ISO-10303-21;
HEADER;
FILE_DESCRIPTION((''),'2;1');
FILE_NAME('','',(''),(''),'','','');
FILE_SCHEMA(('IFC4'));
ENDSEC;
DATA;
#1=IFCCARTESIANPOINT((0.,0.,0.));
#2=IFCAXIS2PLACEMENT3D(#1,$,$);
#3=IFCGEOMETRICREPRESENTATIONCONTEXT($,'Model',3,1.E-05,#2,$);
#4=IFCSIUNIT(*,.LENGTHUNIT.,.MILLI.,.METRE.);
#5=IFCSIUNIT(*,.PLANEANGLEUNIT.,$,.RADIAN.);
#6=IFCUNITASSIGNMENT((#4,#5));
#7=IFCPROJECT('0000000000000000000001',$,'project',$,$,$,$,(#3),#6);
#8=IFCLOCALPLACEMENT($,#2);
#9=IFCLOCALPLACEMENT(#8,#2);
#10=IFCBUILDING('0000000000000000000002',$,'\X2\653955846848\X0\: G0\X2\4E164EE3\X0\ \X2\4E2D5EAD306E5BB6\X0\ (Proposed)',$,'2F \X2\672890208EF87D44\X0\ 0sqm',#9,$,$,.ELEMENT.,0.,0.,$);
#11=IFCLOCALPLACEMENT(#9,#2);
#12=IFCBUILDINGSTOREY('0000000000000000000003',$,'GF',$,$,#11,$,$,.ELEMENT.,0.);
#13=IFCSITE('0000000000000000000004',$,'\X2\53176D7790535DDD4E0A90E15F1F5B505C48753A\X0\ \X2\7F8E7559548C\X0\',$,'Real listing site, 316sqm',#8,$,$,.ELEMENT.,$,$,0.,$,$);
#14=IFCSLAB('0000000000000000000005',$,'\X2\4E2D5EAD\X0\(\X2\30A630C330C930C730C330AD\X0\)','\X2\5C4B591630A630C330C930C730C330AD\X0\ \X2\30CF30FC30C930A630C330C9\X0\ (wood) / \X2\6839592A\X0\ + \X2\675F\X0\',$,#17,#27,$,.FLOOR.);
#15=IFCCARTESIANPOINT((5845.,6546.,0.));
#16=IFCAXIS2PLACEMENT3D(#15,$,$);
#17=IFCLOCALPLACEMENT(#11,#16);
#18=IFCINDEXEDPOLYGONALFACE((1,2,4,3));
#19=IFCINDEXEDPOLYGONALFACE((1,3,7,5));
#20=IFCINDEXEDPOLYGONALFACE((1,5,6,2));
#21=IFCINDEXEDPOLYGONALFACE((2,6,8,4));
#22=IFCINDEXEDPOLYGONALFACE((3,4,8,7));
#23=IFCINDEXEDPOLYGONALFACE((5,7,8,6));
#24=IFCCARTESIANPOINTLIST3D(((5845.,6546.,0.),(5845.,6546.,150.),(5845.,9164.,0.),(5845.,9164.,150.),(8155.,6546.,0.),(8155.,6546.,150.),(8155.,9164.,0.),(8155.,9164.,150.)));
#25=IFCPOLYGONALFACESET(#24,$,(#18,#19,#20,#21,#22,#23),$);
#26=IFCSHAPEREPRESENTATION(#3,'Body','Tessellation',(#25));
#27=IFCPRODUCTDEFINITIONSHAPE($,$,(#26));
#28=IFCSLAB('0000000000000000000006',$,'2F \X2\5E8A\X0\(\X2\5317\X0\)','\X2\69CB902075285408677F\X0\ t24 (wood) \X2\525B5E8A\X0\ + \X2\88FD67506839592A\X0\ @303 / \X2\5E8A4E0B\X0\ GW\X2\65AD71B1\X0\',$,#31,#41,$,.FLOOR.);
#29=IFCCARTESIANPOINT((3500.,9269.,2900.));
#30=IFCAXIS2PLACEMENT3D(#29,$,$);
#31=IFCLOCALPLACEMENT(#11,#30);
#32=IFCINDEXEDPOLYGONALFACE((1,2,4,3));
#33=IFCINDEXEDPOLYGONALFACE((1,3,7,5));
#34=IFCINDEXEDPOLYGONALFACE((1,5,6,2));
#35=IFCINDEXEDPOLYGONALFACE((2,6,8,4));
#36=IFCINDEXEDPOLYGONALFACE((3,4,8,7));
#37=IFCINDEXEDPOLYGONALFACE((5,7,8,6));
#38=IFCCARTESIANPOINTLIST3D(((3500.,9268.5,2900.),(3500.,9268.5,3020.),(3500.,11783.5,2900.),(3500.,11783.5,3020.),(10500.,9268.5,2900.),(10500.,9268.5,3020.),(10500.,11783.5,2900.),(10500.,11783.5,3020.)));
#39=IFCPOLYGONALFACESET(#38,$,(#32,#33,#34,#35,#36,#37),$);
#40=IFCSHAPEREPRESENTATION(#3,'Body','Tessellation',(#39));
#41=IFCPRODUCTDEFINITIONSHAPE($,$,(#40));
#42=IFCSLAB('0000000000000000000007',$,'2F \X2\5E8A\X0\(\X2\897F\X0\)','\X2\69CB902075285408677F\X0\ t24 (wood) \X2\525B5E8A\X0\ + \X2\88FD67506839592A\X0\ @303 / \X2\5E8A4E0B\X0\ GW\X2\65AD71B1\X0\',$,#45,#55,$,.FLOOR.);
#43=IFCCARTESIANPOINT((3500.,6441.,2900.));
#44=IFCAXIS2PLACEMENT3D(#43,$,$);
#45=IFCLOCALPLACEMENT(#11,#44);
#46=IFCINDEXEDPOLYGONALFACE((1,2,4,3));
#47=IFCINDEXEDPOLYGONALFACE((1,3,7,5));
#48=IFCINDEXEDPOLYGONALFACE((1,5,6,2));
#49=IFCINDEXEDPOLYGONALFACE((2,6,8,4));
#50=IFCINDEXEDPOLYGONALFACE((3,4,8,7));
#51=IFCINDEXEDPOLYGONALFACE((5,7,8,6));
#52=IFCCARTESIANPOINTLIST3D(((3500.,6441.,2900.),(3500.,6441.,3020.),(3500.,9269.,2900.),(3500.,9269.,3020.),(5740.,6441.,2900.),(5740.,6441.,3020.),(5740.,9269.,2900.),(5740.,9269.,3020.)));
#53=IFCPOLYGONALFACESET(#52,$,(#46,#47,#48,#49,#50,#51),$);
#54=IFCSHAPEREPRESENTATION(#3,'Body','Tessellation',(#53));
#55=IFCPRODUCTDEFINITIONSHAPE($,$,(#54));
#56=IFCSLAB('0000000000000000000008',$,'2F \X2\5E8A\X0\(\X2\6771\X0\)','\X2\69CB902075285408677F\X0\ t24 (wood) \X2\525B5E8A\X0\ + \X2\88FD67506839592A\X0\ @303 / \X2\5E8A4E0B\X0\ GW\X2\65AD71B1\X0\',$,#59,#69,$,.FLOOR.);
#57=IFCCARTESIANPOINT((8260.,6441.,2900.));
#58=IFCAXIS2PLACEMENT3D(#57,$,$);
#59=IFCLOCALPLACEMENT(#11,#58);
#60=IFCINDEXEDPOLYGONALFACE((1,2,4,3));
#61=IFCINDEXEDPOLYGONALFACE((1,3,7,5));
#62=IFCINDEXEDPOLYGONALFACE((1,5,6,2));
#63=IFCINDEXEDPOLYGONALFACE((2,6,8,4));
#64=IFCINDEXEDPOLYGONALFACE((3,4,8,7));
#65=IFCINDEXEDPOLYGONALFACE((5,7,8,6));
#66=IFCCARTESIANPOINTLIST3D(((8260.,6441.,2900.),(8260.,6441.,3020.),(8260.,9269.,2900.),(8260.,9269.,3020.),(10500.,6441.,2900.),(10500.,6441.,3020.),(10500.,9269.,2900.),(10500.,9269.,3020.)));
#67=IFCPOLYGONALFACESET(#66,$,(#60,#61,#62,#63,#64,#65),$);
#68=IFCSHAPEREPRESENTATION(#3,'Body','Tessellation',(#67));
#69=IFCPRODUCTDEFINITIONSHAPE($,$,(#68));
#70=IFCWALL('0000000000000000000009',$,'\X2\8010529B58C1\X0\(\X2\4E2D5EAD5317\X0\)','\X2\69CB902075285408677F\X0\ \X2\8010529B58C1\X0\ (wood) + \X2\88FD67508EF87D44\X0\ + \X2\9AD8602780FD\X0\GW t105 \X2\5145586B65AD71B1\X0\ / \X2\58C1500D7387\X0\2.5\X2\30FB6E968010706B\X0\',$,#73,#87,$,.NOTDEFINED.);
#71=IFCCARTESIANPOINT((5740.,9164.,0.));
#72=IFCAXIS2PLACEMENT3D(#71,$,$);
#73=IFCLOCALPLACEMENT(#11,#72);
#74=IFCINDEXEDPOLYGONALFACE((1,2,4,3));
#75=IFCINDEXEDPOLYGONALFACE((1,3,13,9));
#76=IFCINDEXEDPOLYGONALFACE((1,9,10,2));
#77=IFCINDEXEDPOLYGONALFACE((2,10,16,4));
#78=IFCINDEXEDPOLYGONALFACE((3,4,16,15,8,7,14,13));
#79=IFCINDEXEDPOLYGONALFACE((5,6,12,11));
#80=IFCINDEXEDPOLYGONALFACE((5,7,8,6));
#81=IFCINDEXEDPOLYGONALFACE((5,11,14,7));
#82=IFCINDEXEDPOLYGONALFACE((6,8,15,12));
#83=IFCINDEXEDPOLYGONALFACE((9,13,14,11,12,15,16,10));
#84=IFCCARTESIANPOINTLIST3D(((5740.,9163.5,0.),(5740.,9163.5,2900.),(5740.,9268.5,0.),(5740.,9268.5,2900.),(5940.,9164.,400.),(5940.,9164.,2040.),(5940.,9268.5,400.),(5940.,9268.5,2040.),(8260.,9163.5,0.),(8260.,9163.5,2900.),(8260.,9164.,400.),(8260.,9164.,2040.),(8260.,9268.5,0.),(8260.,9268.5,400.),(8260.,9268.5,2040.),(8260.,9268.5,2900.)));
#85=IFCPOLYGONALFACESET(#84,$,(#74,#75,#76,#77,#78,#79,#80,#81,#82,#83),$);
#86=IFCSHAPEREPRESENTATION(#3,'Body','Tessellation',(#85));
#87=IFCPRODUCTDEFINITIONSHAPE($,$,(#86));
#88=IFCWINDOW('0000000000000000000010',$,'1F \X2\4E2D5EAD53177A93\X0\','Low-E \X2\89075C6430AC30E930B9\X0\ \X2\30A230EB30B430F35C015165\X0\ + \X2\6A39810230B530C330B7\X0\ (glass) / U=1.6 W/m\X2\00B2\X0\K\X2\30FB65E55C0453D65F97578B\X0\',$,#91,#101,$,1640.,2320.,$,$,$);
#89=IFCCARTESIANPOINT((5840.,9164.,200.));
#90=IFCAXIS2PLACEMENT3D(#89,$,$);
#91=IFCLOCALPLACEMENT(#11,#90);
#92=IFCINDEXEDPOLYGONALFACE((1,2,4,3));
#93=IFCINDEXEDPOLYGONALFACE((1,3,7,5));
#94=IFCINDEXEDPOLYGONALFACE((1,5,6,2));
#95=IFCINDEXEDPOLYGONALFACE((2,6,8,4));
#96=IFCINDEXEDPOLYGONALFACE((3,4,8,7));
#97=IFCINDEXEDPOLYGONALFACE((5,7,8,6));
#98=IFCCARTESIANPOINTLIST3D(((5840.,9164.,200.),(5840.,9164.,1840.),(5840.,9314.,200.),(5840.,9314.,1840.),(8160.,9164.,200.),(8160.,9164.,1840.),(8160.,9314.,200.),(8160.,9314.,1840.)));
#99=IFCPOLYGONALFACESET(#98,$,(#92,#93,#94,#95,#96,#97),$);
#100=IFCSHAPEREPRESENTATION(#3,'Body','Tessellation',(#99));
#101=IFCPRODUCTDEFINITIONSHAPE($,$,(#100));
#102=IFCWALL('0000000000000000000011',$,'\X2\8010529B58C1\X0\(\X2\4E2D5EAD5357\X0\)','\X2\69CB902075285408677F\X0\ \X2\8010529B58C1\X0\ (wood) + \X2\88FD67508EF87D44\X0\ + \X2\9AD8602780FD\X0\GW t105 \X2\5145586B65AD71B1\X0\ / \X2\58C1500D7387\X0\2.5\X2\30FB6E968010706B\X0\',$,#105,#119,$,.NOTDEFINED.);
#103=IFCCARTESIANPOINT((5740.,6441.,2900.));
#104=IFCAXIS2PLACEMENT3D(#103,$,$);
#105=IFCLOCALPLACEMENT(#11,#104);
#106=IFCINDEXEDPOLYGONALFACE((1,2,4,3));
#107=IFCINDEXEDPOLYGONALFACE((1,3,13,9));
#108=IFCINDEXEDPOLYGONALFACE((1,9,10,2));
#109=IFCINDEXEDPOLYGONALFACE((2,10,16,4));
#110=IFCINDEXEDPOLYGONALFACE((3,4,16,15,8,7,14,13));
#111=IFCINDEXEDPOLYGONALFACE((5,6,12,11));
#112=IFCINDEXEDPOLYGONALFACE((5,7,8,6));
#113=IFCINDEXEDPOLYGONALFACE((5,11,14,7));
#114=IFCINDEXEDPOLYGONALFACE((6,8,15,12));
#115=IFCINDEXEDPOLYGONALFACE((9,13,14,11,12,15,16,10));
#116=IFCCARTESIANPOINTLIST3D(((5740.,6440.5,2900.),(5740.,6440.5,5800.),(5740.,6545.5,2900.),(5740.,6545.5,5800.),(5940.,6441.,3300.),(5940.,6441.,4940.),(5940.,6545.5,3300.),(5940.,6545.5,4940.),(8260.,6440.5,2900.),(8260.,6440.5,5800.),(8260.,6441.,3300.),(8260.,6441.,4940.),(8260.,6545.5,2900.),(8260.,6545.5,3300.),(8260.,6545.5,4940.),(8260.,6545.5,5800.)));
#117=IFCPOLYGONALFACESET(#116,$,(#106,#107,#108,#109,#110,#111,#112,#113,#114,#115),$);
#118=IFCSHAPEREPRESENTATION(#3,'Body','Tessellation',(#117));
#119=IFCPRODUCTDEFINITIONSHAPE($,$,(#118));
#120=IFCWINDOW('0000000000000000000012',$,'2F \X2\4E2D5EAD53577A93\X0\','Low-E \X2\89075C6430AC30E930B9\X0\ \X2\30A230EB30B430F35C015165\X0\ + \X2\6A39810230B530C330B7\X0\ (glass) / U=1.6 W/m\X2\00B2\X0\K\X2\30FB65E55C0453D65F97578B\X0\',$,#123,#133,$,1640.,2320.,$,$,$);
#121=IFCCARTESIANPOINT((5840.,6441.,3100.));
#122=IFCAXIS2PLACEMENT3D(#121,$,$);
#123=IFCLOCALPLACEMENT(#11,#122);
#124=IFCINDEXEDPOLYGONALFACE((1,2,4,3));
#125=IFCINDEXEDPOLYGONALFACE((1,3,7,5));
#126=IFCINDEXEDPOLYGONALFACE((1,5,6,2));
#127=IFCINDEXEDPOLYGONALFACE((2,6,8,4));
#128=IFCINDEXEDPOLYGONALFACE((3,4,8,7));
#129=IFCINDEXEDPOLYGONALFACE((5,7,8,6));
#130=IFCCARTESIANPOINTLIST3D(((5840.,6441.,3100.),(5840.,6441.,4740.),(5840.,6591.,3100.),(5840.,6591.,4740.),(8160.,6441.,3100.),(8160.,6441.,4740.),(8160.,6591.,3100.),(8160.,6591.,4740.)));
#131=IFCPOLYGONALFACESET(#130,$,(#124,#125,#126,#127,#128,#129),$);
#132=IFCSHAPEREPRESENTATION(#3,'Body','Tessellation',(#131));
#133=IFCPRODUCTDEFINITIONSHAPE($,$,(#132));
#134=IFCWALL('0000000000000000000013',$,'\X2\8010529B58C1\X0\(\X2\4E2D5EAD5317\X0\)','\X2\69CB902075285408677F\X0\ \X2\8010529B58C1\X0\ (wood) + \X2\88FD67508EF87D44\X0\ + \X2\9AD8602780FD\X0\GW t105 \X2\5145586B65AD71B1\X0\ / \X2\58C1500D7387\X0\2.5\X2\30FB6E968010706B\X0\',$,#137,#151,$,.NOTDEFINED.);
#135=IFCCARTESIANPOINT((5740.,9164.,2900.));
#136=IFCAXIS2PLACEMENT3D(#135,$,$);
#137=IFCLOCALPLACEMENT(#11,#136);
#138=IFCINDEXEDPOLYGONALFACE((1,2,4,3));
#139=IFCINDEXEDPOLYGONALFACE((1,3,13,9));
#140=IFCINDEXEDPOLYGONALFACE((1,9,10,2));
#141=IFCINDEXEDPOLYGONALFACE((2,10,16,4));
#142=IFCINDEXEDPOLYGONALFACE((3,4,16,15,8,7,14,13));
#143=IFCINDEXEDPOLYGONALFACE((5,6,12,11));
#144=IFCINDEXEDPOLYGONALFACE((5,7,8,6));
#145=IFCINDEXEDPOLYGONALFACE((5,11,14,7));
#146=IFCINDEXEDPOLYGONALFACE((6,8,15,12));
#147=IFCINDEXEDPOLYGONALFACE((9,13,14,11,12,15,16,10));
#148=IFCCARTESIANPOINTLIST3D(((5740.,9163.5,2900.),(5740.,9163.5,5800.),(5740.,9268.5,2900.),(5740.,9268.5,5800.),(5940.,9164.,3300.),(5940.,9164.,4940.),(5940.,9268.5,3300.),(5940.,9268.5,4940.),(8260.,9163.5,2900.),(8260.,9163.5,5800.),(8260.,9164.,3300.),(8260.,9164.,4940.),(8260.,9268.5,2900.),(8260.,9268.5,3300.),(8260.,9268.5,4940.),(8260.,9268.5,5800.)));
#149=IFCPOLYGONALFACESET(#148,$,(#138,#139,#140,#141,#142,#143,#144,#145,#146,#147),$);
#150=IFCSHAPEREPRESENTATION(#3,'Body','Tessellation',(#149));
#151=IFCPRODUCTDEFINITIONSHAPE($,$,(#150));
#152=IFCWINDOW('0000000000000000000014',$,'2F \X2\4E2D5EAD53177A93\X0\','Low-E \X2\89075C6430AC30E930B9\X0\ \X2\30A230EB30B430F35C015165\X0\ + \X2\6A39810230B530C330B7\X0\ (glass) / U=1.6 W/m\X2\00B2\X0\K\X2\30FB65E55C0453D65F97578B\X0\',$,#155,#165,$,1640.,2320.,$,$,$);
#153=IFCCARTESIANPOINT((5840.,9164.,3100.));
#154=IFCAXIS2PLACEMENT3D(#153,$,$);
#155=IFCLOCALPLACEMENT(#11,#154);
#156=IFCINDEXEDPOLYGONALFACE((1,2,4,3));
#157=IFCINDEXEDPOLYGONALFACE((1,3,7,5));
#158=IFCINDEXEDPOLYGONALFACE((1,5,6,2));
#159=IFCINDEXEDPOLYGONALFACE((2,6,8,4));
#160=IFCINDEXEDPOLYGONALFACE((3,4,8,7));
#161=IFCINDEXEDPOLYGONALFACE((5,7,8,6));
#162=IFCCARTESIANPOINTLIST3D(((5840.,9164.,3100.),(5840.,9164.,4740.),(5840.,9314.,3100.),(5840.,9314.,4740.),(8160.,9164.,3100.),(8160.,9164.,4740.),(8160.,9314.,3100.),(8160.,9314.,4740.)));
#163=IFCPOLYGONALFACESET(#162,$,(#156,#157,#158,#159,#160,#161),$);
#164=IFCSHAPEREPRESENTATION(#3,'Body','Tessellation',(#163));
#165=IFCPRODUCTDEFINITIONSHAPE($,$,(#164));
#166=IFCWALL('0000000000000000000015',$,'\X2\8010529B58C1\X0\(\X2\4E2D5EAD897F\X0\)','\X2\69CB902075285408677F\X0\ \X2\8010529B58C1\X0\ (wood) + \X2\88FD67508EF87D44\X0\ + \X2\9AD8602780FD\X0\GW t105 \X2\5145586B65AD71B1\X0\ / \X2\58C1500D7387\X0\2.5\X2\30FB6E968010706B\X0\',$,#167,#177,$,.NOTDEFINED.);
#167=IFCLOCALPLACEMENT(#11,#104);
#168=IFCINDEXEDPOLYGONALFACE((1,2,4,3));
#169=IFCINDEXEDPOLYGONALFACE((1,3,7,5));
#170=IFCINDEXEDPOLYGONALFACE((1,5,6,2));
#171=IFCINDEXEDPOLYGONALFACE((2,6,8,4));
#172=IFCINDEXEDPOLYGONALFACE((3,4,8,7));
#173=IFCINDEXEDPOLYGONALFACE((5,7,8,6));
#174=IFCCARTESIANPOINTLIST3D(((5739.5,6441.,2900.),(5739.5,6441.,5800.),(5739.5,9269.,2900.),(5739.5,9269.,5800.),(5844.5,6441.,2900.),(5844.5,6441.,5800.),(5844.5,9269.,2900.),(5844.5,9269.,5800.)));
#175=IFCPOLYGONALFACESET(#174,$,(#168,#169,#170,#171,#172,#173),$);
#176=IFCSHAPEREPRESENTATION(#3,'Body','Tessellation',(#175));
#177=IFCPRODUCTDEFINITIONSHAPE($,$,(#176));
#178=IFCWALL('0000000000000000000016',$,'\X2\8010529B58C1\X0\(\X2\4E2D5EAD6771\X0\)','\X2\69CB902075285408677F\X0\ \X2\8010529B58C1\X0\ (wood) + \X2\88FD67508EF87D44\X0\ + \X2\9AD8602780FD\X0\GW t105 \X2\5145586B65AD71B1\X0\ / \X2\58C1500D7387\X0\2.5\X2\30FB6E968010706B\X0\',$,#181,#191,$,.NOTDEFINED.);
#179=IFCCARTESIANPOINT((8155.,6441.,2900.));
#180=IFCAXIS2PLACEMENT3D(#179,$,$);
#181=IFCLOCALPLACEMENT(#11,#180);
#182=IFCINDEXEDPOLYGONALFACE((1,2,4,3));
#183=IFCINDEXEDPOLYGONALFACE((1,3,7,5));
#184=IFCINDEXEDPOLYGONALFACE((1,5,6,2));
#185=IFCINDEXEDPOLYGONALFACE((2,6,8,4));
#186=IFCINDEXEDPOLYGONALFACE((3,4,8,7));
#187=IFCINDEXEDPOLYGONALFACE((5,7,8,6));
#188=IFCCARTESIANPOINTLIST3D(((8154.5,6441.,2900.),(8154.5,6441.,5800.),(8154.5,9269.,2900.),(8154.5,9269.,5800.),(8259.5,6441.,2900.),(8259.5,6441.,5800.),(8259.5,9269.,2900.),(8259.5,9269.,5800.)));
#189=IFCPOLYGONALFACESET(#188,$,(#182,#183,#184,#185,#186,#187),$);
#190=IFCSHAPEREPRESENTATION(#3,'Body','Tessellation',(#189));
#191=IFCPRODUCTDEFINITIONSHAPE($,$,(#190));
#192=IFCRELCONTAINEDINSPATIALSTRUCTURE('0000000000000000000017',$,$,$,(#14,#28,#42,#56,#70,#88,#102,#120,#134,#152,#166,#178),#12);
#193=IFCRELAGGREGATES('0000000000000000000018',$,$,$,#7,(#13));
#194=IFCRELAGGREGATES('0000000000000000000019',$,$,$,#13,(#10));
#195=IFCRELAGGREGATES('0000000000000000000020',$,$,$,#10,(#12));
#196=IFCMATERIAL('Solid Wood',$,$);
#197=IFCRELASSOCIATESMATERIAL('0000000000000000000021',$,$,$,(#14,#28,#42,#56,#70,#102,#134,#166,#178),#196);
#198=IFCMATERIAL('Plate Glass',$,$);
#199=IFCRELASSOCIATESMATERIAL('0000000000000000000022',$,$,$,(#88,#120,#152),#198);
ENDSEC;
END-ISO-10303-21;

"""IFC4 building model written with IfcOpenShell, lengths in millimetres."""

from ifc_helpers import new_model, si_unit, frame, frame_2d, origin, place, context, project, spatial, rectangle, extrude, material, element, fill, save


model = new_model("IFC4")

# Units and contexts
model_context = context("Model", 3, precision=1e-05, world=origin())
ifc_project = project(units=[si_unit("LENGTHUNIT", "METRE", prefix="MILLI"), si_unit("PLANEANGLEUNIT", "RADIAN")], contexts=[model_context])

# Site, building, storey
site_placement = place(None, origin())
site = spatial("IfcSite", under=ifc_project, at=site_placement, Name="北海道川上郡弟子屈町 美留和", ObjectType="Real listing site, 316sqm", CompositionType="ELEMENT", RefElevation=0.0)
building_placement = place(site_placement, origin())
building = spatial("IfcBuilding", under=site, at=building_placement, Name="改善案: G0世代 中庭の家 (Proposed)", ObjectType="2F 木造軸組 0sqm", CompositionType="ELEMENT", ElevationOfRefHeight=0.0, ElevationOfTerrain=0.0)
storey_placement = place(building_placement, origin())
storey = spatial("IfcBuildingStorey", under=building, at=storey_placement, Name="GF", CompositionType="ELEMENT", Elevation=0.0)

# Slabs
ifc_material_1 = material(Name="Solid Wood")
slab_1_placement = place(storey_placement, frame((5845.0, 6546.0, 0.0)))
element("IfcSlab", 1, at=slab_1_placement, inside=storey, material=ifc_material_1, Name="中庭(ウッドデッキ)", Description="屋外ウッドデッキ ハードウッド (wood) / 根太 + 束", PredefinedType="FLOOR", context=model_context, shape_type="SweptSolid", body=[
    extrude(rectangle(XDim=2310.0, YDim=2618.0, at=frame_2d((1155.0, 1309.0))), frame((5845.0, 6546.0, 0.0)), (0.0, 0.0, 1.0), 150.0),
])
slab_2_placement = place(storey_placement, frame((3500.0, 9269.0, 2900.0)))
element("IfcSlab", 2, at=slab_2_placement, inside=storey, material=ifc_material_1, Name="2F 床(北)", Description="構造用合板 t24 (wood) 剛床 + 製材根太 @303 / 床下 GW断熱", PredefinedType="FLOOR", context=model_context, shape_type="SweptSolid", body=[
    extrude(rectangle(XDim=7000.0, YDim=2515.0, at=frame_2d((3500.0, 1257.0))), frame((3500.0, 9269.0, 2900.0)), (0.0, 0.0, 1.0), 120.0),
])
slab_3_placement = place(storey_placement, frame((3500.0, 6441.0, 2900.0)))
element("IfcSlab", 3, at=slab_3_placement, inside=storey, material=ifc_material_1, Name="2F 床(西)", Description="構造用合板 t24 (wood) 剛床 + 製材根太 @303 / 床下 GW断熱", PredefinedType="FLOOR", context=model_context, shape_type="SweptSolid", body=[
    extrude(rectangle(XDim=2240.0, YDim=2828.0, at=frame_2d((1120.0, 1414.0))), frame((3500.0, 6441.0, 2900.0)), (0.0, 0.0, 1.0), 120.0),
])
slab_4_placement = place(storey_placement, frame((8260.0, 6441.0, 2900.0)))
element("IfcSlab", 4, at=slab_4_placement, inside=storey, material=ifc_material_1, Name="2F 床(東)", Description="構造用合板 t24 (wood) 剛床 + 製材根太 @303 / 床下 GW断熱", PredefinedType="FLOOR", context=model_context, shape_type="SweptSolid", body=[
    extrude(rectangle(XDim=2240.0, YDim=2828.0, at=frame_2d((1120.0, 1414.0))), frame((8260.0, 6441.0, 2900.0)), (0.0, 0.0, 1.0), 120.0),
])

# Wall, opening, window
wall_1_placement = place(storey_placement, frame((5740.0, 9164.0, 0.0)))
wall_1 = element("IfcWall", 5, at=wall_1_placement, inside=storey, material=ifc_material_1, Name="耐力壁(中庭北)", Description="構造用合板 耐力壁 (wood) + 製材軸組 + 高性能GW t105 充填断熱 / 壁倍率2.5・準耐火", PredefinedType="NOTDEFINED", context=model_context, shape_type="SweptSolid", body=[
    extrude(rectangle(XDim=2520.0, YDim=105.0, at=frame_2d((1260.0, 52.0))), frame((5740.0, 9164.0, 0.0)), (0.0, 0.0, 1.0), 2900.0),
])
opening_1_placement = place(storey_placement, frame((5840.0, 9164.0, 200.0)))
opening_1 = element("IfcOpeningElement", 6, at=opening_1_placement, cuts=wall_1, PredefinedType="NOTDEFINED", context=model_context, shape_type="SweptSolid", body=[
    extrude(rectangle(XDim=2320.0, YDim=150.0, at=frame_2d((1160.0, 75.0))), frame((5840.0, 9164.0, 200.0)), (0.0, 0.0, 1.0), 1640.0),
])
ifc_material_2 = material(Name="Plate Glass")
window_1_placement = place(storey_placement, frame((5840.0, 9164.0, 200.0)))
window_1 = element("IfcWindow", 7, at=window_1_placement, inside=storey, material=ifc_material_2, Name="1F 中庭北窓", Description="Low-E 複層ガラス アルゴン封入 + 樹脂サッシ (glass) / U=1.6 W/m²K・日射取得型", OverallHeight=1640.0, OverallWidth=2320.0, context=model_context, shape_type="SweptSolid", body=[
    extrude(rectangle(XDim=2320.0, YDim=150.0, at=frame_2d((1160.0, 75.0))), frame((5840.0, 9164.0, 200.0)), (0.0, 0.0, 1.0), 1640.0),
])
fill(opening_1, window_1)

# Walls, openings, windows
wall_2_placement = place(storey_placement, frame((5740.0, 6441.0, 2900.0)))
wall_2 = element("IfcWall", 8, at=wall_2_placement, inside=storey, material=ifc_material_1, Name="耐力壁(中庭南)", Description="構造用合板 耐力壁 (wood) + 製材軸組 + 高性能GW t105 充填断熱 / 壁倍率2.5・準耐火", PredefinedType="NOTDEFINED", context=model_context, shape_type="SweptSolid", body=[
    extrude(rectangle(XDim=2520.0, YDim=105.0, at=frame_2d((1260.0, 52.0))), frame((5740.0, 6441.0, 2900.0)), (0.0, 0.0, 1.0), 2900.0),
])
opening_2_placement = place(storey_placement, frame((5840.0, 6441.0, 3100.0)))
opening_2 = element("IfcOpeningElement", 9, at=opening_2_placement, cuts=wall_2, PredefinedType="NOTDEFINED", context=model_context, shape_type="SweptSolid", body=[
    extrude(rectangle(XDim=2320.0, YDim=150.0, at=frame_2d((1160.0, 75.0))), frame((5840.0, 6441.0, 3100.0)), (0.0, 0.0, 1.0), 1640.0),
])
window_2_placement = place(storey_placement, frame((5840.0, 6441.0, 3100.0)))
window_2 = element("IfcWindow", 10, at=window_2_placement, inside=storey, material=ifc_material_2, Name="2F 中庭南窓", Description="Low-E 複層ガラス アルゴン封入 + 樹脂サッシ (glass) / U=1.6 W/m²K・日射取得型", OverallHeight=1640.0, OverallWidth=2320.0, context=model_context, shape_type="SweptSolid", body=[
    extrude(rectangle(XDim=2320.0, YDim=150.0, at=frame_2d((1160.0, 75.0))), frame((5840.0, 6441.0, 3100.0)), (0.0, 0.0, 1.0), 1640.0),
])
fill(opening_2, window_2)
wall_3_placement = place(storey_placement, frame((5740.0, 9164.0, 2900.0)))
wall_3 = element("IfcWall", 11, at=wall_3_placement, inside=storey, material=ifc_material_1, Name="耐力壁(中庭北)", Description="構造用合板 耐力壁 (wood) + 製材軸組 + 高性能GW t105 充填断熱 / 壁倍率2.5・準耐火", PredefinedType="NOTDEFINED", context=model_context, shape_type="SweptSolid", body=[
    extrude(rectangle(XDim=2520.0, YDim=105.0, at=frame_2d((1260.0, 52.0))), frame((5740.0, 9164.0, 2900.0)), (0.0, 0.0, 1.0), 2900.0),
])
opening_3_placement = place(storey_placement, frame((5840.0, 9164.0, 3100.0)))
opening_3 = element("IfcOpeningElement", 12, at=opening_3_placement, cuts=wall_3, PredefinedType="NOTDEFINED", context=model_context, shape_type="SweptSolid", body=[
    extrude(rectangle(XDim=2320.0, YDim=150.0, at=frame_2d((1160.0, 75.0))), frame((5840.0, 9164.0, 3100.0)), (0.0, 0.0, 1.0), 1640.0),
])
window_3_placement = place(storey_placement, frame((5840.0, 9164.0, 3100.0)))
window_3 = element("IfcWindow", 13, at=window_3_placement, inside=storey, material=ifc_material_2, Name="2F 中庭北窓", Description="Low-E 複層ガラス アルゴン封入 + 樹脂サッシ (glass) / U=1.6 W/m²K・日射取得型", OverallHeight=1640.0, OverallWidth=2320.0, context=model_context, shape_type="SweptSolid", body=[
    extrude(rectangle(XDim=2320.0, YDim=150.0, at=frame_2d((1160.0, 75.0))), frame((5840.0, 9164.0, 3100.0)), (0.0, 0.0, 1.0), 1640.0),
])
fill(opening_3, window_3)

# Walls
wall_4_placement = place(storey_placement, frame((5740.0, 6441.0, 2900.0)))
element("IfcWall", 14, at=wall_4_placement, inside=storey, material=ifc_material_1, Name="耐力壁(中庭西)", Description="構造用合板 耐力壁 (wood) + 製材軸組 + 高性能GW t105 充填断熱 / 壁倍率2.5・準耐火", PredefinedType="NOTDEFINED", context=model_context, shape_type="SweptSolid", body=[
    extrude(rectangle(XDim=105.0, YDim=2828.0, at=frame_2d((52.0, 1414.0))), frame((5740.0, 6441.0, 2900.0)), (0.0, 0.0, 1.0), 2900.0),
])
wall_5_placement = place(storey_placement, frame((8155.0, 6441.0, 2900.0)))
element("IfcWall", 15, at=wall_5_placement, inside=storey, material=ifc_material_1, Name="耐力壁(中庭東)", Description="構造用合板 耐力壁 (wood) + 製材軸組 + 高性能GW t105 充填断熱 / 壁倍率2.5・準耐火", PredefinedType="NOTDEFINED", context=model_context, shape_type="SweptSolid", body=[
    extrude(rectangle(XDim=105.0, YDim=2828.0, at=frame_2d((52.0, 1414.0))), frame((8155.0, 6441.0, 2900.0)), (0.0, 0.0, 1.0), 2900.0),
])

save(model, "model.ifc")
